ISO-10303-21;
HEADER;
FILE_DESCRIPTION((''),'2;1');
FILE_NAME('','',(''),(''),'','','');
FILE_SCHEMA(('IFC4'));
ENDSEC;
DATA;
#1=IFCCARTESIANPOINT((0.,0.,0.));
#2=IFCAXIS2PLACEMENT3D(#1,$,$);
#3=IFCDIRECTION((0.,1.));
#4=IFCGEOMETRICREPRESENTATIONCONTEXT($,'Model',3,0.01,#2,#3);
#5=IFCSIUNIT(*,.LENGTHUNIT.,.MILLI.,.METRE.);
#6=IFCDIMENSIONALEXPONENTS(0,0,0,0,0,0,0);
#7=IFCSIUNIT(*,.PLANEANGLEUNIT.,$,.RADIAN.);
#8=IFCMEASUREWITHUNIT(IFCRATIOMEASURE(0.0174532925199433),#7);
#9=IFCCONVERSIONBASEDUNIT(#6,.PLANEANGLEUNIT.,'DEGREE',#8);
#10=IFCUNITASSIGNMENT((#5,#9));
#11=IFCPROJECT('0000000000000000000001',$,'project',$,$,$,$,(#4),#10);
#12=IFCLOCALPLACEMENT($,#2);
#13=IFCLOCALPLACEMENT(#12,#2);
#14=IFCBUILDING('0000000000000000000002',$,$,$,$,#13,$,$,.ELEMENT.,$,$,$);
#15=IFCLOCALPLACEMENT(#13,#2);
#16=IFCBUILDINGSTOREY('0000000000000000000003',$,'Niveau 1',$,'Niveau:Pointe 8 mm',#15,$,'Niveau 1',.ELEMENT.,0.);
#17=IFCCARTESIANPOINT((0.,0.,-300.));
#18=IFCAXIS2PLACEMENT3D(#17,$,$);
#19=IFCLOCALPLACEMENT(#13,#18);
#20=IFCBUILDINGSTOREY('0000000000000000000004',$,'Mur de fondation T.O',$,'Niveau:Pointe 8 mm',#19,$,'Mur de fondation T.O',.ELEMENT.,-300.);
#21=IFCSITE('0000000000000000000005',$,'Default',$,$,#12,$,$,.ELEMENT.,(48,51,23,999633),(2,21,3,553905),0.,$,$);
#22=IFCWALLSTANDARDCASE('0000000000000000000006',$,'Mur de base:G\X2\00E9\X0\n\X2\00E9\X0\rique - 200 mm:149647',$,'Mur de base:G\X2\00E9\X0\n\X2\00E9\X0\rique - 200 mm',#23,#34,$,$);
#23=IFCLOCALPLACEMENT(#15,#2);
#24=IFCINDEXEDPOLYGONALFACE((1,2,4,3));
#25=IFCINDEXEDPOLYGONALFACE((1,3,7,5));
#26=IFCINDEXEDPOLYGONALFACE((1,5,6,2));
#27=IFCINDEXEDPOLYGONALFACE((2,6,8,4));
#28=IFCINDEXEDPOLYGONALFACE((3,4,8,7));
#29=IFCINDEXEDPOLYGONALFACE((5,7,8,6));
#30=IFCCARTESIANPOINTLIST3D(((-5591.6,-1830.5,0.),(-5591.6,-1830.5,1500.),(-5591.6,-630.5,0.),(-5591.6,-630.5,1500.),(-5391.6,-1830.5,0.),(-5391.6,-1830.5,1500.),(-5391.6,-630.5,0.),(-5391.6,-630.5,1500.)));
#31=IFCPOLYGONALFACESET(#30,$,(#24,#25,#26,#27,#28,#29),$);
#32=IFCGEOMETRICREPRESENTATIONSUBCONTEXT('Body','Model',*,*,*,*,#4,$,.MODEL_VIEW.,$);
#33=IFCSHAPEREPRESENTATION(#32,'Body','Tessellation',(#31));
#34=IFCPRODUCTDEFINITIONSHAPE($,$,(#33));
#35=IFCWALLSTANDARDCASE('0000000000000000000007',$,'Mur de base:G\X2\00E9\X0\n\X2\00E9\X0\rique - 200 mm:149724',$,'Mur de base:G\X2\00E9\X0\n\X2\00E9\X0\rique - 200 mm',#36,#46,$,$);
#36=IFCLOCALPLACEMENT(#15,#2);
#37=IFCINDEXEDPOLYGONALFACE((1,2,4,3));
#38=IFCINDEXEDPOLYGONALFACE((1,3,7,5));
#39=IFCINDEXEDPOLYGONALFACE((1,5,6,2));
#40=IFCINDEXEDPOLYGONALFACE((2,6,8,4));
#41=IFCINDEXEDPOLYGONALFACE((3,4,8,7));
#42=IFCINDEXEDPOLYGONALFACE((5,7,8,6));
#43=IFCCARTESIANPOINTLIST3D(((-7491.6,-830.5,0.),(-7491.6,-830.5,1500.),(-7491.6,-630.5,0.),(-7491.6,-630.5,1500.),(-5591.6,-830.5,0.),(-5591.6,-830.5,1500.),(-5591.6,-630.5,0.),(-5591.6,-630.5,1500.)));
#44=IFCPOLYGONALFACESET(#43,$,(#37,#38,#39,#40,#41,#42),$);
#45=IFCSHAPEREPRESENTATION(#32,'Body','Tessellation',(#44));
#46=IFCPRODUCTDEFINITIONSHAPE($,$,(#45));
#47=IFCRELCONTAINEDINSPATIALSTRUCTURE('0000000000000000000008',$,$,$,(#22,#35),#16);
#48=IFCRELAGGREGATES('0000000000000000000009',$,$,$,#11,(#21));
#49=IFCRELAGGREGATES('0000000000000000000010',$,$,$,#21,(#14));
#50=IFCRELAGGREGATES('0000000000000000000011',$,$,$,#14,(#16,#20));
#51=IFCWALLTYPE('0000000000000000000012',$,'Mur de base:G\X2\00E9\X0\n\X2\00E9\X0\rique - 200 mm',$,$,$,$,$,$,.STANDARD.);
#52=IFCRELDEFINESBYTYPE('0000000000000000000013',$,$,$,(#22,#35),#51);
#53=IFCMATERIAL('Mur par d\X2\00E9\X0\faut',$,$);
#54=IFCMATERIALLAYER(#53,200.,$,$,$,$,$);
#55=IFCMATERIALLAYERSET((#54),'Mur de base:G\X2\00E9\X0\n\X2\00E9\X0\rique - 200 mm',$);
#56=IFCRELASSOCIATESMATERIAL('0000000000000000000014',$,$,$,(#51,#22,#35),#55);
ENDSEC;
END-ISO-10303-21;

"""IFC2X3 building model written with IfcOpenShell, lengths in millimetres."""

from ifc_helpers import new_model, entity, si_unit, converted_unit, direction, frame, frame_2d, origin, place, context, subcontext, project, spatial, rectangle, extrude, material, layer, layer_set, layer_usage, type_object, element, save


model = new_model("IFC2X3")

# Units and contexts
model_context = context("Model", 3, precision=0.01, world=origin(), true_north=direction((0.0, 1.0)))
body_context = subcontext(model_context, "Body", "Model", "MODEL_VIEW")
ifc_project = project(units=[si_unit("LENGTHUNIT", "METRE", prefix="MILLI"), converted_unit("PLANEANGLEUNIT", "DEGREE", entity("IfcRatioMeasure", 0.0174532925199433), si_unit("PLANEANGLEUNIT", "RADIAN"), dimensions=[0, 0, 0, 0, 0, 0, 0])], contexts=[model_context])

# Site, building, storey
site_placement = place(None, origin())
site = spatial("IfcSite", under=ifc_project, at=site_placement, Name="Default", CompositionType="ELEMENT", RefLatitude=(48, 51, 23, 999633), RefLongitude=(2, 21, 3, 553905), RefElevation=0.0)
building_placement = place(site_placement, origin())
building = spatial("IfcBuilding", under=site, at=building_placement, CompositionType="ELEMENT")
storey_1_placement = place(building_placement, origin())
storey_1 = spatial("IfcBuildingStorey", under=building, at=storey_1_placement, Name="Niveau 1", ObjectType="Niveau:Pointe 8 mm", LongName="Niveau 1", CompositionType="ELEMENT", Elevation=0.0)

# Shared definitions
ifc_material_1 = material(Name="Mur par défaut")
ifc_layer_1 = layer(ifc_material_1, 200.0)
ifc_layer_set_1 = layer_set([ifc_layer_1], Name="Mur de base:Générique - 200 mm")
wall_type = type_object("IfcWallType", Name="Mur de base:Générique - 200 mm", PredefinedType="STANDARD", material=ifc_layer_set_1)

# Shared definitions
storey_2_placement = place(building_placement, frame((0.0, 0.0, -300.0)))
storey_2 = spatial("IfcBuildingStorey", under=building, at=storey_2_placement, Name="Mur de fondation T.O", ObjectType="Niveau:Pointe 8 mm", LongName="Mur de fondation T.O", CompositionType="ELEMENT", Elevation=-300.0)

# Walls
ifc_layer_usage_1 = layer_usage(ifc_layer_set_1, "AXIS2", "NEGATIVE", 100.0)
wall_1_placement = place(storey_1_placement, frame((-5491.6, -1830.5, 0.0), z_axis=(0.0, 0.0, 1.0), x_axis=(0.0, 1.0, 0.0)))
element("IfcWallStandardCase", 1, at=wall_1_placement, inside=storey_1, type_object=wall_type, material=ifc_layer_usage_1, Name="Mur de base:Générique - 200 mm:149647", ObjectType="Mur de base:Générique - 200 mm", context=body_context, shape_type="SweptSolid", body=[
    extrude(rectangle(XDim=1200.0, YDim=200.0, at=frame_2d((600.0, 0.0), x_axis=(-1.0, 0.0))), origin(), (0.0, 0.0, 1.0), 1500.0),
])
ifc_layer_usage_2 = layer_usage(ifc_layer_set_1, "AXIS2", "NEGATIVE", 100.0)
wall_2_placement = place(storey_1_placement, frame((-5591.6, -730.5, 0.0), z_axis=(0.0, 0.0, 1.0), x_axis=(-1.0, 0.0, 0.0)))
element("IfcWallStandardCase", 2, at=wall_2_placement, inside=storey_1, type_object=wall_type, material=ifc_layer_usage_2, Name="Mur de base:Générique - 200 mm:149724", ObjectType="Mur de base:Générique - 200 mm", context=body_context, shape_type="SweptSolid", body=[
    extrude(rectangle(XDim=1900.0, YDim=200.0, at=frame_2d((950.0, 0.0), x_axis=(-1.0, 0.0))), origin(), (0.0, 0.0, 1.0), 1500.0),
])

save(model, "model.ifc")
